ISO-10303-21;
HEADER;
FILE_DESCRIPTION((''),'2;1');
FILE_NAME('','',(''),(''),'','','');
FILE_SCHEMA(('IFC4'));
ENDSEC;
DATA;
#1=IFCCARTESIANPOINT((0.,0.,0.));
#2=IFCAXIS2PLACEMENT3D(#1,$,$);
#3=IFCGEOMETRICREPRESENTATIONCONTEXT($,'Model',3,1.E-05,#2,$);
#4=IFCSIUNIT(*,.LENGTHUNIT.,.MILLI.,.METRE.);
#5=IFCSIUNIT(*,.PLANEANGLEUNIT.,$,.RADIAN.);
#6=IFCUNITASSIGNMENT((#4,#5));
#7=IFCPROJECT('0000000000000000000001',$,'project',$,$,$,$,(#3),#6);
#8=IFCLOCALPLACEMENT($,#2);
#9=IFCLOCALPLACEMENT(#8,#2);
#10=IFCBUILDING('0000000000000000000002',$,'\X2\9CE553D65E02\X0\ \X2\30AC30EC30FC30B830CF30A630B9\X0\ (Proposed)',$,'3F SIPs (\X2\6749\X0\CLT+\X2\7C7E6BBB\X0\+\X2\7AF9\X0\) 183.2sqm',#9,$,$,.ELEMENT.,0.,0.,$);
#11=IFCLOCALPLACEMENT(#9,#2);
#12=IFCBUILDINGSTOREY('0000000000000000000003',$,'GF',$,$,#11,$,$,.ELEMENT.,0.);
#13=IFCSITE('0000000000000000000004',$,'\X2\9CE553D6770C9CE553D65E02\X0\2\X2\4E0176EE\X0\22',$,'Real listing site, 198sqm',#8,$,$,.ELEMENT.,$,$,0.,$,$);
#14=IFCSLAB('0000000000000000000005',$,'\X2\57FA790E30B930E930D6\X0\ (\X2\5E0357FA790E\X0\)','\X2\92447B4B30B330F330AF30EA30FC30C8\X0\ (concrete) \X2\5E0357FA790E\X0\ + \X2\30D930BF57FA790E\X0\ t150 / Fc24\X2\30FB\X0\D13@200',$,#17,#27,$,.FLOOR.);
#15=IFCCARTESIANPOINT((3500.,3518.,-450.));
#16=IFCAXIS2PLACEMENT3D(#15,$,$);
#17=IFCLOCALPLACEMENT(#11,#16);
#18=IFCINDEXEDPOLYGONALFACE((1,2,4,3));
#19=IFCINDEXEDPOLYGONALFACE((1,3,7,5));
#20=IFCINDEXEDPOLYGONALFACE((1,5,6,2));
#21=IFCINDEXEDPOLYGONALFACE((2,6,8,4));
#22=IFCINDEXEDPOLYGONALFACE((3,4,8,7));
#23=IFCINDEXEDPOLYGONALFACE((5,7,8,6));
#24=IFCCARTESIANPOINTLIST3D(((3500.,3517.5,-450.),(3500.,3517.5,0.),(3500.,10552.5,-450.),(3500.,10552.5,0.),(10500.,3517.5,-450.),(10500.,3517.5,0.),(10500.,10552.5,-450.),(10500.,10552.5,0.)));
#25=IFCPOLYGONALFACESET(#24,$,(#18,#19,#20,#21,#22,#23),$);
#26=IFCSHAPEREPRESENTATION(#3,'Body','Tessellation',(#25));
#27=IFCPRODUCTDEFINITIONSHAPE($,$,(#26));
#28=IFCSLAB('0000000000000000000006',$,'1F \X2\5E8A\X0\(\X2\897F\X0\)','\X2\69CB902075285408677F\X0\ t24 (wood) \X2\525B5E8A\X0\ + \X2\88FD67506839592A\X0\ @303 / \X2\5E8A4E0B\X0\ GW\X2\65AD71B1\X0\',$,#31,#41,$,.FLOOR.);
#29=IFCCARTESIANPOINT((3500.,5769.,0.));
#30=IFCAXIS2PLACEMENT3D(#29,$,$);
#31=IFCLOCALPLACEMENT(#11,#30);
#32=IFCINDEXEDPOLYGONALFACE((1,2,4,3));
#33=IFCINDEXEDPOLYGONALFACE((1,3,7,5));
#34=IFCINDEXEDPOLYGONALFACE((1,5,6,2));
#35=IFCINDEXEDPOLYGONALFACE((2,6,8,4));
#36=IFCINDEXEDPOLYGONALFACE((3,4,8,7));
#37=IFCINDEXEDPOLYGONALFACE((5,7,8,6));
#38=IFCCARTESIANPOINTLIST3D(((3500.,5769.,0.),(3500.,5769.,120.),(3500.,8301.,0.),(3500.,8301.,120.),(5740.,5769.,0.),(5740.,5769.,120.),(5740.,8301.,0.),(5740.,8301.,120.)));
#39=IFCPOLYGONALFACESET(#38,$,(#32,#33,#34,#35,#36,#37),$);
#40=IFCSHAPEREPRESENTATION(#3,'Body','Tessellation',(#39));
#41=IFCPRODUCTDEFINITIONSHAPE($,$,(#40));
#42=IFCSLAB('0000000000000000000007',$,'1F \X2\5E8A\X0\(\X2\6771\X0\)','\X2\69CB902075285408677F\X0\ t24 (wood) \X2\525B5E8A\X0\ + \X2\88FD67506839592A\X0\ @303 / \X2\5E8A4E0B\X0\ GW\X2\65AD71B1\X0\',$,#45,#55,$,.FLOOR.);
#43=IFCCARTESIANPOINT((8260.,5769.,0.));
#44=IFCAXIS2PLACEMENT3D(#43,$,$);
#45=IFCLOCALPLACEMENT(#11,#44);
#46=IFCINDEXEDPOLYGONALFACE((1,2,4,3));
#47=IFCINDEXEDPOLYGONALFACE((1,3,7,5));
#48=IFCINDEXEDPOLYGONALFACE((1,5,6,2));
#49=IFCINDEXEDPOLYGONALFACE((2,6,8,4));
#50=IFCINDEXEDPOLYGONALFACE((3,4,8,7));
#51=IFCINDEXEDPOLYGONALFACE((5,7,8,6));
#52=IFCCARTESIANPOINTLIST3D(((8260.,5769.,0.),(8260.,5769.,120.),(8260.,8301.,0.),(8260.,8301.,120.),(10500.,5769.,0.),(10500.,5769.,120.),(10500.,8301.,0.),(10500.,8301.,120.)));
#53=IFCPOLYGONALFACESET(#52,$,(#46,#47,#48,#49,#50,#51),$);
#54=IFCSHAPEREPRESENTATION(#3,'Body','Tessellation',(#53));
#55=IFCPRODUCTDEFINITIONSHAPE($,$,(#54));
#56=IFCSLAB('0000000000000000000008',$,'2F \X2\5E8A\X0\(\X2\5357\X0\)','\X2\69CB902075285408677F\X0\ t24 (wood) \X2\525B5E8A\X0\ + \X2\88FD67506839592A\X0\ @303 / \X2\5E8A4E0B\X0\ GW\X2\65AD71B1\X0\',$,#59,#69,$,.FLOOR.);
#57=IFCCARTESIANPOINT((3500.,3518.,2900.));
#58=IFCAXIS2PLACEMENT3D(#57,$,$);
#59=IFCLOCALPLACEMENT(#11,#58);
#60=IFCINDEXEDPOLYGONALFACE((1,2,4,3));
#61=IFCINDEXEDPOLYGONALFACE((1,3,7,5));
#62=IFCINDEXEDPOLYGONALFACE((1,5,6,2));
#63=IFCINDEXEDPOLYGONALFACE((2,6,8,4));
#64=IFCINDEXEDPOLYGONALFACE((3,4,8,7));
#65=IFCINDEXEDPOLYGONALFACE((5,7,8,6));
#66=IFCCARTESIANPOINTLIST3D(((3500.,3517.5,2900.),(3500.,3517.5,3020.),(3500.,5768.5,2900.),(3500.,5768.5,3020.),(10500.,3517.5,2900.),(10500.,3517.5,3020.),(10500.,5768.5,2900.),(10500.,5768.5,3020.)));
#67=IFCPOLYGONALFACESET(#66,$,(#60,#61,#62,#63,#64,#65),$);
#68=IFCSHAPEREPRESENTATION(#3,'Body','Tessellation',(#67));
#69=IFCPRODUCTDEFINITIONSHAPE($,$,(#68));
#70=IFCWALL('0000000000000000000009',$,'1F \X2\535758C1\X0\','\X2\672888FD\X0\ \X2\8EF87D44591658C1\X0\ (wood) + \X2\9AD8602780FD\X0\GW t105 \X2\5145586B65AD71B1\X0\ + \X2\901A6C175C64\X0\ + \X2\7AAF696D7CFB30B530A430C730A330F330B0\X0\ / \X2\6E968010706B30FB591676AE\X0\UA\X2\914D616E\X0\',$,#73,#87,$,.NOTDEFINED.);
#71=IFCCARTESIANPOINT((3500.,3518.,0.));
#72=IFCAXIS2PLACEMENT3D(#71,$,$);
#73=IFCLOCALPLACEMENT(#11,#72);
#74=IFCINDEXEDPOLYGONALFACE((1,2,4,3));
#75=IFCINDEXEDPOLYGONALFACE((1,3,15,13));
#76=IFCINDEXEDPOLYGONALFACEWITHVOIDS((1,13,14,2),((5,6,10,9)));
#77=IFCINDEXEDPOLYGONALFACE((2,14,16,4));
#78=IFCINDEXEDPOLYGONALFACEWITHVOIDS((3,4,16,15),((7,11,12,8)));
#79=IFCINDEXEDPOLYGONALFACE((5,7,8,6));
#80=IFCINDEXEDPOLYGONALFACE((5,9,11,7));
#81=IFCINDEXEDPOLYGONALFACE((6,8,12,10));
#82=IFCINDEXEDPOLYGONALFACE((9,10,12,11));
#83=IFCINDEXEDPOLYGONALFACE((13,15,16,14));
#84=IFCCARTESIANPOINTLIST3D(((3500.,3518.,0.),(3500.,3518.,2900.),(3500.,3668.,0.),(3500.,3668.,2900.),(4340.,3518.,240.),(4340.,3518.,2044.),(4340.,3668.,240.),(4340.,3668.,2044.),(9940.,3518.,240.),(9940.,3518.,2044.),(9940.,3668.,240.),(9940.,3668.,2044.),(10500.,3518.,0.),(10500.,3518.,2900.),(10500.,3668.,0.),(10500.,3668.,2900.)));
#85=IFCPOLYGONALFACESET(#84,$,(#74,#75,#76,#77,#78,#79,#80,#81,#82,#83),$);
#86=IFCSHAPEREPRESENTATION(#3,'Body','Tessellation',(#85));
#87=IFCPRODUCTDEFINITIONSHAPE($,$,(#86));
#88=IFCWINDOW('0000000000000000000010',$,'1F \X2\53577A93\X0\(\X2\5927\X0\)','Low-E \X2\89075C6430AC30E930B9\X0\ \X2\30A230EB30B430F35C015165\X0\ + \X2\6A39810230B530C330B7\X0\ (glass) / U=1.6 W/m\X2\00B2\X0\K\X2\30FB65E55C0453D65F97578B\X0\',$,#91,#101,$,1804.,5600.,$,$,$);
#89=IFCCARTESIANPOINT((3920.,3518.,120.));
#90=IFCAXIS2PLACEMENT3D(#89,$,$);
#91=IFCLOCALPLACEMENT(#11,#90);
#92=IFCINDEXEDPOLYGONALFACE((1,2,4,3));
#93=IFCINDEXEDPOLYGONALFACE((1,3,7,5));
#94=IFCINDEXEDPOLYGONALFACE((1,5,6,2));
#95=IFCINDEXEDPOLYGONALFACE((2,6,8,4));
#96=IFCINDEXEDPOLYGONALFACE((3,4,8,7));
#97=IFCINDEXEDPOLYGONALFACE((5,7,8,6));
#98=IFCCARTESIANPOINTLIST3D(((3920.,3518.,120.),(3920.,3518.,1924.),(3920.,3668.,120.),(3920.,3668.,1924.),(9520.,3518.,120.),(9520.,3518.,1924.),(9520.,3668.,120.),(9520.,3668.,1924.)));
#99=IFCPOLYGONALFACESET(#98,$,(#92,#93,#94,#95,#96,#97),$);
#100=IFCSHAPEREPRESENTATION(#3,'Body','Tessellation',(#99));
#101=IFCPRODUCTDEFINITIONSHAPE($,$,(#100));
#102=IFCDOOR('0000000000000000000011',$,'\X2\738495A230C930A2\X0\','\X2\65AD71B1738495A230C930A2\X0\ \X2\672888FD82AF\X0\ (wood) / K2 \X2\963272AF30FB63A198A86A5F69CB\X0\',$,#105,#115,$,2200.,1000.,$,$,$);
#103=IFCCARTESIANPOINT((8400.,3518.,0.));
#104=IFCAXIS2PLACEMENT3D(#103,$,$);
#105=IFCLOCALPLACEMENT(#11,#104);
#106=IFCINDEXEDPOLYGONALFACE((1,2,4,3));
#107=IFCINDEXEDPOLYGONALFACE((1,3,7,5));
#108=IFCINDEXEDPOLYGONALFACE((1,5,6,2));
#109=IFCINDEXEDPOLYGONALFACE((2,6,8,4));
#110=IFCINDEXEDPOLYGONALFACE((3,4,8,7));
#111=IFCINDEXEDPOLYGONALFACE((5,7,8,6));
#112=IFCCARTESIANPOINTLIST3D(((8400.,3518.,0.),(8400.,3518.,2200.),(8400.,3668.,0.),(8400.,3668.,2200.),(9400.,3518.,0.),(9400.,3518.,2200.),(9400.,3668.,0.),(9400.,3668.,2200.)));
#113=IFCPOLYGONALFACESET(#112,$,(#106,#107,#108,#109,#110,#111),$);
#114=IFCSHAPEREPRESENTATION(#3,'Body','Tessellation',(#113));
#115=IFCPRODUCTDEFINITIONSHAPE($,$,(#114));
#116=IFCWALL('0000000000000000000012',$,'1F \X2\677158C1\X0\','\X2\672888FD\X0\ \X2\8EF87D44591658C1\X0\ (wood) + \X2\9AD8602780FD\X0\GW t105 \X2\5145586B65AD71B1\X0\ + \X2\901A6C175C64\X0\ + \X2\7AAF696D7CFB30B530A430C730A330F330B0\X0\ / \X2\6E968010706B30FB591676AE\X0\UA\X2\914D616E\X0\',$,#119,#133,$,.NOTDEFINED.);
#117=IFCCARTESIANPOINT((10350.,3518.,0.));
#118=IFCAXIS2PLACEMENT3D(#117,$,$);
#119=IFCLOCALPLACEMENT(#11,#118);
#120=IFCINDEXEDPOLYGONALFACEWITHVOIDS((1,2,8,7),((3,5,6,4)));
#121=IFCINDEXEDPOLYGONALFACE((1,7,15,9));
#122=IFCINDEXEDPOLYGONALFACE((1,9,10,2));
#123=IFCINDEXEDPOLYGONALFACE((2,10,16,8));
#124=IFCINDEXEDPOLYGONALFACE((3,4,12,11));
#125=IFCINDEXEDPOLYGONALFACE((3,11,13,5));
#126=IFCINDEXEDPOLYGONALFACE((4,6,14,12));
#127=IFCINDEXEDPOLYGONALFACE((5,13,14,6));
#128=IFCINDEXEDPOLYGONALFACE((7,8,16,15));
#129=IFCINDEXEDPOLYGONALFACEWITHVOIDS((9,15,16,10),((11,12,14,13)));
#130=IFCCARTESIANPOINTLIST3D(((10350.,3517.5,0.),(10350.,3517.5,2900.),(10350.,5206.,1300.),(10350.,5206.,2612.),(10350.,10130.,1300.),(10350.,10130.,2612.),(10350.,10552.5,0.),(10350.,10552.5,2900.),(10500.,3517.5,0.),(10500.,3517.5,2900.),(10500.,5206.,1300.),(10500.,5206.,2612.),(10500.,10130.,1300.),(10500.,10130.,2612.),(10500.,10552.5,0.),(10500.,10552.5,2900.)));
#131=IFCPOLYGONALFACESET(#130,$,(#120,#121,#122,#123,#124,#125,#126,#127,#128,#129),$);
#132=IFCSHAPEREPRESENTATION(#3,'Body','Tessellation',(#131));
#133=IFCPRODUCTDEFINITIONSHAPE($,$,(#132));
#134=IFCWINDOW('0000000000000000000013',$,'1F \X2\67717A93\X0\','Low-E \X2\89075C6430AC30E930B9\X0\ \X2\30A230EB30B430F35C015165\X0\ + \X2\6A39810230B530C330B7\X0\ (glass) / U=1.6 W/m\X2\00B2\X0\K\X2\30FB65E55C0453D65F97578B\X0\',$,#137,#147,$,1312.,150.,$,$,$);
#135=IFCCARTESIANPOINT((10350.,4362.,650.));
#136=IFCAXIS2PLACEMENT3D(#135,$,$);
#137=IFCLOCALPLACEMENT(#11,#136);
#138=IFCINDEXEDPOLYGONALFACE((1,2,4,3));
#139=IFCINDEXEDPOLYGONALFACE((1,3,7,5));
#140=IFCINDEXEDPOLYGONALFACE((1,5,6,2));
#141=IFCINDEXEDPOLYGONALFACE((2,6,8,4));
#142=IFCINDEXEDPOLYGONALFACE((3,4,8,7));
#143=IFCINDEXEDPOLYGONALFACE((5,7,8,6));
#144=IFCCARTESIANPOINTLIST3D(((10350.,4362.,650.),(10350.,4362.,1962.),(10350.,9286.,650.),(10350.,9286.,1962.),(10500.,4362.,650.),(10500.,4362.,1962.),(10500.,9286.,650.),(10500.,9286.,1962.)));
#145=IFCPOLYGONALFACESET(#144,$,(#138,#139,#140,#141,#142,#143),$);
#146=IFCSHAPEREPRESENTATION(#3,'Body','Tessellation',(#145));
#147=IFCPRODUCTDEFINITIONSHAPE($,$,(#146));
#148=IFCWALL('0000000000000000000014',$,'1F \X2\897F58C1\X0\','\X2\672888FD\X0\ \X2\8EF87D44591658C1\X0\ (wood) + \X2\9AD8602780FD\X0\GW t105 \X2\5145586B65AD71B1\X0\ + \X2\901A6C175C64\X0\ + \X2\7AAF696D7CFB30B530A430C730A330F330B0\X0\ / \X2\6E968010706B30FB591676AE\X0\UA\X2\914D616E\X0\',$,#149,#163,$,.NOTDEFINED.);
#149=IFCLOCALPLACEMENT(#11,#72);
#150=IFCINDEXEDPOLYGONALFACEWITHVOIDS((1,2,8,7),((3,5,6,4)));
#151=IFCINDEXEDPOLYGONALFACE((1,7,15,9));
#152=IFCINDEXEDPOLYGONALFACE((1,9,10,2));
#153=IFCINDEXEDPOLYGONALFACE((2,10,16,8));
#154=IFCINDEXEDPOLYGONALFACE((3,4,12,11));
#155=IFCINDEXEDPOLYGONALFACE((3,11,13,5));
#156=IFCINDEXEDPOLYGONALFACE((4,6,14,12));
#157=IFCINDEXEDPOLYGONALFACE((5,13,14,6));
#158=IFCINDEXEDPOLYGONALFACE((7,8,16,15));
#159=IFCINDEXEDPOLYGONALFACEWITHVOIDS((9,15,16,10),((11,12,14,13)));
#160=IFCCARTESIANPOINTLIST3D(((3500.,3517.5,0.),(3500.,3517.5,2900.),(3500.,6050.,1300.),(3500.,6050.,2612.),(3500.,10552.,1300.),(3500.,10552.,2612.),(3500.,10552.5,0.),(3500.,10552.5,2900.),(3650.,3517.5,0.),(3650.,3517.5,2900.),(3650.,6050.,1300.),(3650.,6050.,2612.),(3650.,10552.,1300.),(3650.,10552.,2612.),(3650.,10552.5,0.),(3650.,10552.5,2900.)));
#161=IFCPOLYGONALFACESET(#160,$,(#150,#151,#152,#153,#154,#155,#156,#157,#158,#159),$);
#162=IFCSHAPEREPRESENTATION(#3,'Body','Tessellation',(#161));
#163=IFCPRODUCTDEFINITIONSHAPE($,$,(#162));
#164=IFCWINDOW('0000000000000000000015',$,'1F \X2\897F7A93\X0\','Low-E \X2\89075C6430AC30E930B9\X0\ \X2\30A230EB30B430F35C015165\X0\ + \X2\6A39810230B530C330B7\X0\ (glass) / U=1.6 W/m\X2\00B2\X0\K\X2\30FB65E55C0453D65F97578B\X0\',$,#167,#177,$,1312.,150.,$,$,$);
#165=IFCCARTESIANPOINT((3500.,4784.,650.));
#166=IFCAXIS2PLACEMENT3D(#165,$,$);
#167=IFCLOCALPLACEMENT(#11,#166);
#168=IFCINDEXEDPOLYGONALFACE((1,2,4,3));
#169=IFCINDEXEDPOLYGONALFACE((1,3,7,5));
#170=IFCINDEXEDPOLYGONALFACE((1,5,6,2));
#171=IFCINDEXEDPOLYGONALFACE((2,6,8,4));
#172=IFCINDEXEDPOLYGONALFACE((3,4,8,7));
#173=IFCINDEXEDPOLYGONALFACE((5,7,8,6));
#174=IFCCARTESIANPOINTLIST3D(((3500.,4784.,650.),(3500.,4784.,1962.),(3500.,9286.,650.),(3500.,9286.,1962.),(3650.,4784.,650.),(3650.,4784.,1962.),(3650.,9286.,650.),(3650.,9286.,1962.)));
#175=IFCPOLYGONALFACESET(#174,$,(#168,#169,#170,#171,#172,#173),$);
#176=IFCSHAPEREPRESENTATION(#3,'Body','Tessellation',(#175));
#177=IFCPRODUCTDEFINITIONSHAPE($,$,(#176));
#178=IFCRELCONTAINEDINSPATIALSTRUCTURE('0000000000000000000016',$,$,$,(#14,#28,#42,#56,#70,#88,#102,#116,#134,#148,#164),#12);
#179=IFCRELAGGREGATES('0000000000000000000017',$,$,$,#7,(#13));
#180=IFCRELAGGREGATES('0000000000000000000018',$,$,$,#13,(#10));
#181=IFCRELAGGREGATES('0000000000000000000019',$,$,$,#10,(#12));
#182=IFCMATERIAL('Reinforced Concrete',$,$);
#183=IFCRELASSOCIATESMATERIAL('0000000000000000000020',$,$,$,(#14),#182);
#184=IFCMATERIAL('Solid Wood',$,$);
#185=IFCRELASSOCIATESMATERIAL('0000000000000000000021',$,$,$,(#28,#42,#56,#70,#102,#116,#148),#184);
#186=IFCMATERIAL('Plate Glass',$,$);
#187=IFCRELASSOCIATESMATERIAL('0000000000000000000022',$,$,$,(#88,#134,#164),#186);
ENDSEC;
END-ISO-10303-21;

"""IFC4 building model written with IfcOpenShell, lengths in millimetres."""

from ifc_helpers import new_model, si_unit, frame, frame_2d, origin, place, context, project, spatial, rectangle, extrude, material, element, fill, save


model = new_model("IFC4")

# Units and contexts
model_context = context("Model", 3, precision=1e-05, world=origin())
ifc_project = project(units=[si_unit("LENGTHUNIT", "METRE", prefix="MILLI"), si_unit("PLANEANGLEUNIT", "RADIAN")], contexts=[model_context])

# Site, building, storey
site_placement = place(None, origin())
site = spatial("IfcSite", under=ifc_project, at=site_placement, Name="鳥取県鳥取市2丁目22", ObjectType="Real listing site, 198sqm", CompositionType="ELEMENT", RefElevation=0.0)
building_placement = place(site_placement, origin())
building = spatial("IfcBuilding", under=site, at=building_placement, Name="鳥取市 ガレージハウス (Proposed)", ObjectType="3F SIPs (杉CLT+籾殻+竹) 183.2sqm", CompositionType="ELEMENT", ElevationOfRefHeight=0.0, ElevationOfTerrain=0.0)
storey_placement = place(building_placement, origin())
storey = spatial("IfcBuildingStorey", under=building, at=storey_placement, Name="GF", CompositionType="ELEMENT", Elevation=0.0)

# Slabs
ifc_material_1 = material(Name="Reinforced Concrete")
slab_1_placement = place(storey_placement, frame((3500.0, 3518.0, -450.0)))
element("IfcSlab", 1, at=slab_1_placement, inside=storey, material=ifc_material_1, Name="基礎スラブ (布基礎)", Description="鉄筋コンクリート (concrete) 布基礎 + ベタ基礎 t150 / Fc24・D13@200", PredefinedType="FLOOR", context=model_context, shape_type="SweptSolid", body=[
    extrude(rectangle(XDim=7000.0, YDim=7035.0, at=frame_2d((3500.0, 3517.0))), frame((3500.0, 3518.0, -450.0)), (0.0, 0.0, 1.0), 450.0),
])
ifc_material_2 = material(Name="Solid Wood")
slab_2_placement = place(storey_placement, frame((3500.0, 5769.0, 0.0)))
element("IfcSlab", 2, at=slab_2_placement, inside=storey, material=ifc_material_2, Name="1F 床(西)", Description="構造用合板 t24 (wood) 剛床 + 製材根太 @303 / 床下 GW断熱", PredefinedType="FLOOR", context=model_context, shape_type="SweptSolid", body=[
    extrude(rectangle(XDim=2240.0, YDim=2532.0, at=frame_2d((1120.0, 1266.0))), frame((3500.0, 5769.0, 0.0)), (0.0, 0.0, 1.0), 120.0),
])
slab_3_placement = place(storey_placement, frame((8260.0, 5769.0, 0.0)))
element("IfcSlab", 3, at=slab_3_placement, inside=storey, material=ifc_material_2, Name="1F 床(東)", Description="構造用合板 t24 (wood) 剛床 + 製材根太 @303 / 床下 GW断熱", PredefinedType="FLOOR", context=model_context, shape_type="SweptSolid", body=[
    extrude(rectangle(XDim=2240.0, YDim=2532.0, at=frame_2d((1120.0, 1266.0))), frame((8260.0, 5769.0, 0.0)), (0.0, 0.0, 1.0), 120.0),
])
slab_4_placement = place(storey_placement, frame((3500.0, 3518.0, 2900.0)))
element("IfcSlab", 4, at=slab_4_placement, inside=storey, material=ifc_material_2, Name="2F 床(南)", Description="構造用合板 t24 (wood) 剛床 + 製材根太 @303 / 床下 GW断熱", PredefinedType="FLOOR", context=model_context, shape_type="SweptSolid", body=[
    extrude(rectangle(XDim=7000.0, YDim=2251.0, at=frame_2d((3500.0, 1125.0))), frame((3500.0, 3518.0, 2900.0)), (0.0, 0.0, 1.0), 120.0),
])

# Wall, openings, window, door
wall_1_placement = place(storey_placement, frame((3500.0, 3518.0, 0.0)))
wall_1 = element("IfcWall", 5, at=wall_1_placement, inside=storey, material=ifc_material_2, Name="1F 南壁", Description="木製 軸組外壁 (wood) + 高性能GW t105 充填断熱 + 通気層 + 窯業系サイディング / 準耐火・外皮UA配慮", PredefinedType="NOTDEFINED", context=model_context, shape_type="SweptSolid", body=[
    extrude(rectangle(XDim=7000.0, YDim=150.0, at=frame_2d((3500.0, 75.0))), frame((3500.0, 3518.0, 0.0)), (0.0, 0.0, 1.0), 2900.0),
])
opening_1_placement = place(storey_placement, frame((3920.0, 3518.0, 120.0)))
opening_1 = element("IfcOpeningElement", 6, at=opening_1_placement, cuts=wall_1, PredefinedType="NOTDEFINED", context=model_context, shape_type="SweptSolid", body=[
    extrude(rectangle(XDim=5600.0, YDim=150.0, at=frame_2d((2800.0, 75.0))), frame((3920.0, 3518.0, 120.0)), (0.0, 0.0, 1.0), 1804.0),
])
opening_2_placement = place(storey_placement, frame((8400.0, 3518.0, 0.0)))
opening_2 = element("IfcOpeningElement", 7, at=opening_2_placement, cuts=wall_1, PredefinedType="NOTDEFINED", context=model_context, shape_type="SweptSolid", body=[
    extrude(rectangle(XDim=1000.0, YDim=150.0, at=frame_2d((500.0, 75.0))), frame((8400.0, 3518.0, 0.0)), (0.0, 0.0, 1.0), 2200.0),
])
ifc_material_3 = material(Name="Plate Glass")
window_1_placement = place(storey_placement, frame((3920.0, 3518.0, 120.0)))
window_1 = element("IfcWindow", 8, at=window_1_placement, inside=storey, material=ifc_material_3, Name="1F 南窓(大)", Description="Low-E 複層ガラス アルゴン封入 + 樹脂サッシ (glass) / U=1.6 W/m²K・日射取得型", OverallHeight=1804.0, OverallWidth=5600.0, context=model_context, shape_type="SweptSolid", body=[
    extrude(rectangle(XDim=5600.0, YDim=150.0, at=frame_2d((2800.0, 75.0))), frame((3920.0, 3518.0, 120.0)), (0.0, 0.0, 1.0), 1804.0),
])
fill(opening_1, window_1)
door_placement = place(storey_placement, frame((8400.0, 3518.0, 0.0)))
door = element("IfcDoor", 9, at=door_placement, inside=storey, material=ifc_material_2, Name="玄関ドア", Description="断熱玄関ドア 木製芯 (wood) / K2 防犯・採風機構", OverallHeight=2200.0, OverallWidth=1000.0, context=model_context, shape_type="SweptSolid", body=[
    extrude(rectangle(XDim=1000.0, YDim=150.0, at=frame_2d((500.0, 75.0))), frame((8400.0, 3518.0, 0.0)), (0.0, 0.0, 1.0), 2200.0),
])
fill(opening_2, door)

# Walls, openings, windows
wall_2_placement = place(storey_placement, frame((10350.0, 3518.0, 0.0)))
wall_2 = element("IfcWall", 10, at=wall_2_placement, inside=storey, material=ifc_material_2, Name="1F 東壁", Description="木製 軸組外壁 (wood) + 高性能GW t105 充填断熱 + 通気層 + 窯業系サイディング / 準耐火・外皮UA配慮", PredefinedType="NOTDEFINED", context=model_context, shape_type="SweptSolid", body=[
    extrude(rectangle(XDim=150.0, YDim=7035.0, at=frame_2d((75.0, 3517.0))), frame((10350.0, 3518.0, 0.0)), (0.0, 0.0, 1.0), 2900.0),
])
opening_3_placement = place(storey_placement, frame((10350.0, 4362.0, 650.0)))
opening_3 = element("IfcOpeningElement", 11, at=opening_3_placement, cuts=wall_2, PredefinedType="NOTDEFINED", context=model_context, shape_type="SweptSolid", body=[
    extrude(rectangle(XDim=150.0, YDim=4924.0, at=frame_2d((75.0, 2462.0))), frame((10350.0, 4362.0, 650.0)), (0.0, 0.0, 1.0), 1312.0),
])
window_2_placement = place(storey_placement, frame((10350.0, 4362.0, 650.0)))
window_2 = element("IfcWindow", 12, at=window_2_placement, inside=storey, material=ifc_material_3, Name="1F 東窓", Description="Low-E 複層ガラス アルゴン封入 + 樹脂サッシ (glass) / U=1.6 W/m²K・日射取得型", OverallHeight=1312.0, OverallWidth=150.0, context=model_context, shape_type="SweptSolid", body=[
    extrude(rectangle(XDim=150.0, YDim=4924.0, at=frame_2d((75.0, 2462.0))), frame((10350.0, 4362.0, 650.0)), (0.0, 0.0, 1.0), 1312.0),
])
fill(opening_3, window_2)
wall_3_placement = place(storey_placement, frame((3500.0, 3518.0, 0.0)))
wall_3 = element("IfcWall", 13, at=wall_3_placement, inside=storey, material=ifc_material_2, Name="1F 西壁", Description="木製 軸組外壁 (wood) + 高性能GW t105 充填断熱 + 通気層 + 窯業系サイディング / 準耐火・外皮UA配慮", PredefinedType="NOTDEFINED", context=model_context, shape_type="SweptSolid", body=[
    extrude(rectangle(XDim=150.0, YDim=7035.0, at=frame_2d((75.0, 3517.0))), frame((3500.0, 3518.0, 0.0)), (0.0, 0.0, 1.0), 2900.0),
])
opening_4_placement = place(storey_placement, frame((3500.0, 4784.0, 650.0)))
opening_4 = element("IfcOpeningElement", 14, at=opening_4_placement, cuts=wall_3, PredefinedType="NOTDEFINED", context=model_context, shape_type="SweptSolid", body=[
    extrude(rectangle(XDim=150.0, YDim=4502.0, at=frame_2d((75.0, 2251.0))), frame((3500.0, 4784.0, 650.0)), (0.0, 0.0, 1.0), 1312.0),
])
window_3_placement = place(storey_placement, frame((3500.0, 4784.0, 650.0)))
window_3 = element("IfcWindow", 15, at=window_3_placement, inside=storey, material=ifc_material_3, Name="1F 西窓", Description="Low-E 複層ガラス アルゴン封入 + 樹脂サッシ (glass) / U=1.6 W/m²K・日射取得型", OverallHeight=1312.0, OverallWidth=150.0, context=model_context, shape_type="SweptSolid", body=[
    extrude(rectangle(XDim=150.0, YDim=4502.0, at=frame_2d((75.0, 2251.0))), frame((3500.0, 4784.0, 650.0)), (0.0, 0.0, 1.0), 1312.0),
])
fill(opening_4, window_3)

save(model, "model.ifc")
